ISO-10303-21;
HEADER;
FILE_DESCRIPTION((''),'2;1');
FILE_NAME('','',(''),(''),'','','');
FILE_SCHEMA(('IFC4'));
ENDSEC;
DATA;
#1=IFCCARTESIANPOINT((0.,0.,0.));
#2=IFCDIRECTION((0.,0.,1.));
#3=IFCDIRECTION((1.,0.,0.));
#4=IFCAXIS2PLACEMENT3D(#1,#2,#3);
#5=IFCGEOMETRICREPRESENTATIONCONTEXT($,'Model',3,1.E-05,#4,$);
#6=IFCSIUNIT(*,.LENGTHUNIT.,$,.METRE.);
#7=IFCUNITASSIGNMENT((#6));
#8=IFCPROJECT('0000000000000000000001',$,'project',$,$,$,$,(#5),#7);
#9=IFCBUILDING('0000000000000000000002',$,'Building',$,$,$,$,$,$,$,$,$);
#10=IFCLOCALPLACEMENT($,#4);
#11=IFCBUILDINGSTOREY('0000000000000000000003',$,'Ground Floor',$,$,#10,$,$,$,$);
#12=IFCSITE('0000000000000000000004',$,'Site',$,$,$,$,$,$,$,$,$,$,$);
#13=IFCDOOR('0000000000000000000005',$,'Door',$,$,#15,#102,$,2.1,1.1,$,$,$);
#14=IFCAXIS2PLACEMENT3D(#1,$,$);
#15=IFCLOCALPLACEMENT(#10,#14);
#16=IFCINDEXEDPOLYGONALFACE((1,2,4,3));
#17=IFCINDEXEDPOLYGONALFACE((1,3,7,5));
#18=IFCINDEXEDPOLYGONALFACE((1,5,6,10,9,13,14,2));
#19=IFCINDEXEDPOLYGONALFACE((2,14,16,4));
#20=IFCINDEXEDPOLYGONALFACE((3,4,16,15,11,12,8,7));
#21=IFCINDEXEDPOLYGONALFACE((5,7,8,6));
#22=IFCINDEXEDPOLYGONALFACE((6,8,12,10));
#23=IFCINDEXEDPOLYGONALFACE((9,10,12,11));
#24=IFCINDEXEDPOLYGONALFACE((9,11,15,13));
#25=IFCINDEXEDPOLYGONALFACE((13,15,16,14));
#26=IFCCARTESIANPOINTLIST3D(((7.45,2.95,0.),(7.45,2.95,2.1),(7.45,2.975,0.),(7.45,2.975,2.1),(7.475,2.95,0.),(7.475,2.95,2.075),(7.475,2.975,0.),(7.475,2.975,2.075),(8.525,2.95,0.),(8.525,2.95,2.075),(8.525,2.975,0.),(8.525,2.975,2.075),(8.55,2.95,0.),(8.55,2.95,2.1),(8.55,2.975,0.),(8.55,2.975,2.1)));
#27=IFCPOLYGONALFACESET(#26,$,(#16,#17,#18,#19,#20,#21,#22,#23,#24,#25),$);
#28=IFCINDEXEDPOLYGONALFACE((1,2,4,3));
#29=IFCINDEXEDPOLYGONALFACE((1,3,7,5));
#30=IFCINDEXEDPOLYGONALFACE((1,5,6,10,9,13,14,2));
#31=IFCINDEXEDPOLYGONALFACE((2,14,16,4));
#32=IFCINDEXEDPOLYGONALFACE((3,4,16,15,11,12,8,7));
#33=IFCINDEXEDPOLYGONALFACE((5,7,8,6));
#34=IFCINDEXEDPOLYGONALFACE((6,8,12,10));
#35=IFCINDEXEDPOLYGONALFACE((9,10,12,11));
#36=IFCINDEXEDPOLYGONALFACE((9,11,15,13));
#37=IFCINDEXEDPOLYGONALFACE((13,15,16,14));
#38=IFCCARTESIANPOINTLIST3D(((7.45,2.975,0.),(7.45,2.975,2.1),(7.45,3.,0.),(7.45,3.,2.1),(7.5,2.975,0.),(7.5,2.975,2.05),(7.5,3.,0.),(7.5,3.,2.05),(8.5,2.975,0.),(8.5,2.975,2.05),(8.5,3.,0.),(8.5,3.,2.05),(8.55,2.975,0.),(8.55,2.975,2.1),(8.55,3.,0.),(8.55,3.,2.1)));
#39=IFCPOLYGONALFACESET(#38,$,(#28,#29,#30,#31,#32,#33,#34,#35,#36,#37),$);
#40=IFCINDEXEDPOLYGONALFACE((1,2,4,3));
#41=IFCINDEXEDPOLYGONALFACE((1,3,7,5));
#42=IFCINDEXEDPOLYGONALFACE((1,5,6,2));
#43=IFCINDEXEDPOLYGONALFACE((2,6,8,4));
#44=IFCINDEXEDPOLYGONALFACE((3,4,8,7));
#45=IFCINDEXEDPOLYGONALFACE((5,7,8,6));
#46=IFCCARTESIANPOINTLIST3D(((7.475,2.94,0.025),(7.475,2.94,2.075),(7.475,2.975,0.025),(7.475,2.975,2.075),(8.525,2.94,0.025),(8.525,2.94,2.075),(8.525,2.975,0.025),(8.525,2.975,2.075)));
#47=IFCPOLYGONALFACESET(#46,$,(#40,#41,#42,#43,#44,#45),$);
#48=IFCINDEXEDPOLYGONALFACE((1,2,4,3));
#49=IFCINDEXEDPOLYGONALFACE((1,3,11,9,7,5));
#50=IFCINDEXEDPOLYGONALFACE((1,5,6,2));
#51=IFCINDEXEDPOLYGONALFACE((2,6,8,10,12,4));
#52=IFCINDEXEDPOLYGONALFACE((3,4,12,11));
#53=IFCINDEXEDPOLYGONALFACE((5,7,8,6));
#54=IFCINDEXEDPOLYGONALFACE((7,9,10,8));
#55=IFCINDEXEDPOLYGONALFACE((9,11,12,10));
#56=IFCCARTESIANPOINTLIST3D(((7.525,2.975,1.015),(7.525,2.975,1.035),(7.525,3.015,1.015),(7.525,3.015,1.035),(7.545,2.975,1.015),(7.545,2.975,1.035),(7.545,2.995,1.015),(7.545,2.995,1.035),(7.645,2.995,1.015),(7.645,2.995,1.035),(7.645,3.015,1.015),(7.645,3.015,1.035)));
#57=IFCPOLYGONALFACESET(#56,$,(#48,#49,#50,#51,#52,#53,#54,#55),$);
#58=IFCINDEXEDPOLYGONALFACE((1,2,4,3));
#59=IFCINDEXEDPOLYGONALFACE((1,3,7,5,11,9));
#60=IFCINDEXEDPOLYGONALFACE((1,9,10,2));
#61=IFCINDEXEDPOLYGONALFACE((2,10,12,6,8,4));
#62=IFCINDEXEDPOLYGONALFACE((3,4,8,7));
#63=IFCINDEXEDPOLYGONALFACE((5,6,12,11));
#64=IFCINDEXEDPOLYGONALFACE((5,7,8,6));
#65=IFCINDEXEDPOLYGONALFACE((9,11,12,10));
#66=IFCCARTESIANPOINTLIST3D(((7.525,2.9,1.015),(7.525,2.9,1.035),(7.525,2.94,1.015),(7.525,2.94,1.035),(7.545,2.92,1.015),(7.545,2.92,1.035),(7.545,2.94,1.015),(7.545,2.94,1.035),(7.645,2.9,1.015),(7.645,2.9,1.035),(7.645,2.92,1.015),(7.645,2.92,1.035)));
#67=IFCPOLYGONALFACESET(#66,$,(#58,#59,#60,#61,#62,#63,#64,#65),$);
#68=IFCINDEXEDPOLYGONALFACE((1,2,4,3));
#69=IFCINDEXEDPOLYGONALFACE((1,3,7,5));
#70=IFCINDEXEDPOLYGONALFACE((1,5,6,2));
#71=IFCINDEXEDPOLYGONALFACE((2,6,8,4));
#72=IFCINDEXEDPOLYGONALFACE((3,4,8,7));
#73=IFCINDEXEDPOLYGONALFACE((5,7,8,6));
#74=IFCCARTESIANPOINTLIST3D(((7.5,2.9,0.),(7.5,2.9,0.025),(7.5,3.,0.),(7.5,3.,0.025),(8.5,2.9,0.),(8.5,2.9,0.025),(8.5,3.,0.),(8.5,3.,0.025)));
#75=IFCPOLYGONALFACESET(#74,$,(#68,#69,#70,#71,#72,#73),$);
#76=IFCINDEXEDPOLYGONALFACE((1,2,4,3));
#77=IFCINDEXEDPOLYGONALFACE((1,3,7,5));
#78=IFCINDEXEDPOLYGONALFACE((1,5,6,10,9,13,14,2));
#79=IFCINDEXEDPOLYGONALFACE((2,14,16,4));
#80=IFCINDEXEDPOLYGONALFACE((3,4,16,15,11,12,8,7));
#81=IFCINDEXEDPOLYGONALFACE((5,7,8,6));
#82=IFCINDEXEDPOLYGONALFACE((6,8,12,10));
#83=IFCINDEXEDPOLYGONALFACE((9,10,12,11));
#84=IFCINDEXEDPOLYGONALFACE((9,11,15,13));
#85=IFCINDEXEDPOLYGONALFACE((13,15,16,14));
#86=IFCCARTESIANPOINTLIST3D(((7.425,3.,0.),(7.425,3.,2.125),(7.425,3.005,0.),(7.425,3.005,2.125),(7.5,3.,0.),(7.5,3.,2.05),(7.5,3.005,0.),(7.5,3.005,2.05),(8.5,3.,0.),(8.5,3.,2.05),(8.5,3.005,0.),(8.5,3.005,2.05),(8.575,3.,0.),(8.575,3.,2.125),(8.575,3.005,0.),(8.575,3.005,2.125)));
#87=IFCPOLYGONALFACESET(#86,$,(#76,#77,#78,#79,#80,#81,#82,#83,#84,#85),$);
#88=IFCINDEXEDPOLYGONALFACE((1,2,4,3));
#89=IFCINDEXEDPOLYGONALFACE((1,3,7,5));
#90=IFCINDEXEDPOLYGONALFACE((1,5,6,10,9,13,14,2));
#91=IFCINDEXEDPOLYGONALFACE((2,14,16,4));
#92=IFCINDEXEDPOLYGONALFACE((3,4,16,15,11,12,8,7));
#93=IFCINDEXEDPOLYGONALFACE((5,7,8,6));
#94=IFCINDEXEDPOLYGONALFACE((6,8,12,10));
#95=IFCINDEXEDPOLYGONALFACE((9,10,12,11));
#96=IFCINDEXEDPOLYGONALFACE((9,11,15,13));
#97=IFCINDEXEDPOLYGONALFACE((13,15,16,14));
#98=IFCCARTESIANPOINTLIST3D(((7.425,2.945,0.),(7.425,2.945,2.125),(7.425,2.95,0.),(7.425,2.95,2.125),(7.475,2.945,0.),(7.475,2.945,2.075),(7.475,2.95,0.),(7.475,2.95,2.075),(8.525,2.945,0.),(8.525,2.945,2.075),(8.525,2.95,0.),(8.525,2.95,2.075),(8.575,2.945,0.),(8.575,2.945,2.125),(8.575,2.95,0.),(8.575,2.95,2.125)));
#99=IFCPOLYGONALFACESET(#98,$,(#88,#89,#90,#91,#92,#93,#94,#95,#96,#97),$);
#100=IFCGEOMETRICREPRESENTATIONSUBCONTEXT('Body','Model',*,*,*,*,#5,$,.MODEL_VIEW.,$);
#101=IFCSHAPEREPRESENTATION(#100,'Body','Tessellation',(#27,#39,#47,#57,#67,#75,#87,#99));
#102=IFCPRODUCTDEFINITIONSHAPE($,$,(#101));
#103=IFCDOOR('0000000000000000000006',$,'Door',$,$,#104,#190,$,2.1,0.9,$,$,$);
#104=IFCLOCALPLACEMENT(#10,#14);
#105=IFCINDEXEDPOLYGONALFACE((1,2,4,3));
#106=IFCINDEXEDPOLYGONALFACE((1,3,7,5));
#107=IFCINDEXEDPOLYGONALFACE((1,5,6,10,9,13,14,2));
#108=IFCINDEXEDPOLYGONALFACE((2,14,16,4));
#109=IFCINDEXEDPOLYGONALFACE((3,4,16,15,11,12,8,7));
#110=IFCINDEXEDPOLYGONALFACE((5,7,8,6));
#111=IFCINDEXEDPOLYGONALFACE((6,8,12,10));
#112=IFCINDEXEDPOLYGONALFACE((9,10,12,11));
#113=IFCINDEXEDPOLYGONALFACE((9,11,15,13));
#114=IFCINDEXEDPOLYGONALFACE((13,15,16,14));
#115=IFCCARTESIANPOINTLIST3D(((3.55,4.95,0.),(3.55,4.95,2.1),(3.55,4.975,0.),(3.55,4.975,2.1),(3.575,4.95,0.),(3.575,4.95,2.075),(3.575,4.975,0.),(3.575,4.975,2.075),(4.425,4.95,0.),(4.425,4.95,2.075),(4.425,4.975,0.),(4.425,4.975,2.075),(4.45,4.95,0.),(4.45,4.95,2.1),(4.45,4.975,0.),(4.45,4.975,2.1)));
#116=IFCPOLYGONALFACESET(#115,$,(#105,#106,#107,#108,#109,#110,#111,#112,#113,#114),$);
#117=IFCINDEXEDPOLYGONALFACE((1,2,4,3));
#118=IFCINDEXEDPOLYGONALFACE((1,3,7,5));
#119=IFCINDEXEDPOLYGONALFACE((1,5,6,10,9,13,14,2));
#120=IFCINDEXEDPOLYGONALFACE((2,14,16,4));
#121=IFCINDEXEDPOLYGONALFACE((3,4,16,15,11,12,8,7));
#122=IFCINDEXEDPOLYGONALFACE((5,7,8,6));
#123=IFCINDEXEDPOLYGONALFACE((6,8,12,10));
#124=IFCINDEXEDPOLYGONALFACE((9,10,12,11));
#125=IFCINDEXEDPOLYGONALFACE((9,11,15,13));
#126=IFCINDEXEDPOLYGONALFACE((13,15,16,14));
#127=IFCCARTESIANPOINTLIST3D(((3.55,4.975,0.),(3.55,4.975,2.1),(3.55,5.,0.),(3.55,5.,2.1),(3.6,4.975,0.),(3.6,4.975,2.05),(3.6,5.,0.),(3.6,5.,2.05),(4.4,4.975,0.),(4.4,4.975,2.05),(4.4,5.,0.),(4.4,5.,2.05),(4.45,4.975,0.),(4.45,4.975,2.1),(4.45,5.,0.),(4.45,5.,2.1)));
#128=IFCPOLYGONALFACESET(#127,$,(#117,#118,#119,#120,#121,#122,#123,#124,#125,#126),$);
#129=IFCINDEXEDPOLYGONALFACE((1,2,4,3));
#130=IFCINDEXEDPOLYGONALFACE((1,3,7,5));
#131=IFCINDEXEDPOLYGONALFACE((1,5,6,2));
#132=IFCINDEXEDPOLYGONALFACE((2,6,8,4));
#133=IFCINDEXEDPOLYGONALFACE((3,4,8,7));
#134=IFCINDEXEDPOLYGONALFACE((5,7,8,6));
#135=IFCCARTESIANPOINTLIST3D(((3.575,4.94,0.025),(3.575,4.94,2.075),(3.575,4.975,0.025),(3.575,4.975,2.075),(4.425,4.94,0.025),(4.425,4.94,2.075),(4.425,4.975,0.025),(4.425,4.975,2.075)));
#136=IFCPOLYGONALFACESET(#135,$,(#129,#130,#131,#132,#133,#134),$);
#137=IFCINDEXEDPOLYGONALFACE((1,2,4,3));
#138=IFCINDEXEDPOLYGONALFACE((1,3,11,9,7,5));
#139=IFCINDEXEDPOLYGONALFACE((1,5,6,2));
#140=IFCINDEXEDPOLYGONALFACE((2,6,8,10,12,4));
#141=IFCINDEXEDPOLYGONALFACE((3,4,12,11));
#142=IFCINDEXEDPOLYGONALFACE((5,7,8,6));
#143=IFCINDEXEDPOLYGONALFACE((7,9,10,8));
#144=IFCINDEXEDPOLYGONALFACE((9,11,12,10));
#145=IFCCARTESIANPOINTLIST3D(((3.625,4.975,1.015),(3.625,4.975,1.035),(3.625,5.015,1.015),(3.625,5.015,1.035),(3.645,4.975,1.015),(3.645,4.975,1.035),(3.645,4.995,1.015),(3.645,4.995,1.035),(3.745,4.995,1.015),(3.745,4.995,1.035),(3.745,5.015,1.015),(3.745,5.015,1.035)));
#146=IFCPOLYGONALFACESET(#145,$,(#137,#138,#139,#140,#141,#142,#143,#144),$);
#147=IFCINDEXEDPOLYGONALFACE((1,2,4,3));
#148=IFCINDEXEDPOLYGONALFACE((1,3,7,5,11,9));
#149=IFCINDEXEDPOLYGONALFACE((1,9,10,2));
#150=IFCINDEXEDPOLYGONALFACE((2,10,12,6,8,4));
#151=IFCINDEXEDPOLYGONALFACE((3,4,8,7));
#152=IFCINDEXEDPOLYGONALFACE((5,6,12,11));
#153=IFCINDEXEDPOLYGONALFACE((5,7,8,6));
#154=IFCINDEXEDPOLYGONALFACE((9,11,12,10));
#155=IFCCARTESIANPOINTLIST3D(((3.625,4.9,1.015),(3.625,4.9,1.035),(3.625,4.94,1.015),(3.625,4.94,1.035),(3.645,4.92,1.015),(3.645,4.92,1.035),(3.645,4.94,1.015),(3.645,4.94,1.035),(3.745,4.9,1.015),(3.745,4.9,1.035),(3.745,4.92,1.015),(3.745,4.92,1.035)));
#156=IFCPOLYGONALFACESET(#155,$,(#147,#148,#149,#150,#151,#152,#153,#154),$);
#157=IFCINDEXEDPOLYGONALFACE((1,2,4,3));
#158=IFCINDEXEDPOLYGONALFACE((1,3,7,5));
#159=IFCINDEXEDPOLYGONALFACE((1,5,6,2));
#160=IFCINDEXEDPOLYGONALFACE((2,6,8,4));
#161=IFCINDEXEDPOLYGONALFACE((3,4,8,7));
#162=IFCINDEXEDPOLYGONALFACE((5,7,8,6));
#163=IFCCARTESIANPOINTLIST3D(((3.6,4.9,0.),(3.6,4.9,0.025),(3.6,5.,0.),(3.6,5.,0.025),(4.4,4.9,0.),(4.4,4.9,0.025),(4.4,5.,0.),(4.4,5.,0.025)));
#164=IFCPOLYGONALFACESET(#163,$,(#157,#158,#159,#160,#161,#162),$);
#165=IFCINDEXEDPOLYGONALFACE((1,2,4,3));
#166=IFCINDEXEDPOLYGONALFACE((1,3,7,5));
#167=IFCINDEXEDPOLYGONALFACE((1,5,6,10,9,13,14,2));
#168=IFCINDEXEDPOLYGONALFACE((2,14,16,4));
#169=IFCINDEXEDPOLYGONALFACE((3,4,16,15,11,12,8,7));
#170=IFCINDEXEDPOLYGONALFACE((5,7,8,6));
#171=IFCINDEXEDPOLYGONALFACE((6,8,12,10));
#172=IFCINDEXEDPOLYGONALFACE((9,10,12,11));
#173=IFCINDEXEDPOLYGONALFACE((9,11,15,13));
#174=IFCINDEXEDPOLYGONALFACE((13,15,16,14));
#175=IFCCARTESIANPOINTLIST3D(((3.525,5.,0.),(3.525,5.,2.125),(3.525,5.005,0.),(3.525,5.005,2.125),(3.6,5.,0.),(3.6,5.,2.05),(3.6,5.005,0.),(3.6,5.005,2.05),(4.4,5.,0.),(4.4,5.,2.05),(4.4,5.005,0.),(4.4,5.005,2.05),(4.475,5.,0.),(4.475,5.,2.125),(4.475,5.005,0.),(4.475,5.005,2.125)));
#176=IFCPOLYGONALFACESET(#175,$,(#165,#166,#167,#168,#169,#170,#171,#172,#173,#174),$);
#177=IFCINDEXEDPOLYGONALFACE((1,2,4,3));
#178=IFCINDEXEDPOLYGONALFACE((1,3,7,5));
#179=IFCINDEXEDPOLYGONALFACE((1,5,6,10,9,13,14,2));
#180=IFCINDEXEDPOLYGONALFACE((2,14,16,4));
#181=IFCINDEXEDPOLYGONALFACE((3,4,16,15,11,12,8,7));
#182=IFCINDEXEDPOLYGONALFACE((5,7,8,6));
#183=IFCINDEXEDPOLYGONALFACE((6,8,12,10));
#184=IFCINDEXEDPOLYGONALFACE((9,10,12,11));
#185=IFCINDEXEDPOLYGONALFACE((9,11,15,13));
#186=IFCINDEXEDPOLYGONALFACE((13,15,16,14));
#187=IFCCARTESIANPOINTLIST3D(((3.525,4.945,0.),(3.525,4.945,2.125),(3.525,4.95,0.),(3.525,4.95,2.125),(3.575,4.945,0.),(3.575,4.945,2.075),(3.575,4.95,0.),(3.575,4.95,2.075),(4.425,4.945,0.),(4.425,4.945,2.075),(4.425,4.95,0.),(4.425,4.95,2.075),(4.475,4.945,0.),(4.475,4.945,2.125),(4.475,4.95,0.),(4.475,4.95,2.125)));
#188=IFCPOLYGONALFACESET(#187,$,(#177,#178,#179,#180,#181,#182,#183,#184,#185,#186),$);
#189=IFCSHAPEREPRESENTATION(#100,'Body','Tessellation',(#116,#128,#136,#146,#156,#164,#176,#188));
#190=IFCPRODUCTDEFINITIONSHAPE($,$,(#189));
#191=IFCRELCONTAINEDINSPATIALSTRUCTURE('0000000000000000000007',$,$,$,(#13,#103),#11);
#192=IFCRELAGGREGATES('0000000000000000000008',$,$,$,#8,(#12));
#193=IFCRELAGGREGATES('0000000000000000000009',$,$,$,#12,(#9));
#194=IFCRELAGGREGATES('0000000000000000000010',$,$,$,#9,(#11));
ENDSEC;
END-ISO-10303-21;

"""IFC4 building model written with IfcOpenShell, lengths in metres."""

from ifc_helpers import new_model, si_unit, frame, origin_with_axes, place, context, subcontext, project, spatial, line, indexed_curve, outline, extrude, element, save


model = new_model("IFC4")

# Units and contexts
model_context = context("Model", 3, precision=1e-05, world=origin_with_axes())
body_context = subcontext(model_context, "Body", "Model", "MODEL_VIEW")
ifc_project = project(units=[si_unit("LENGTHUNIT", "METRE")], contexts=[model_context])

# Site, building, storey
site = spatial("IfcSite", under=ifc_project, Name="Site")
building = spatial("IfcBuilding", under=site, Name="Building")
storey_placement = place(None, origin_with_axes())
storey = spatial("IfcBuildingStorey", under=building, at=storey_placement, Name="Ground Floor")

# Doors
door_1_placement = place(storey_placement, frame((8.55, 3.0, 0.0), z_axis=(0.0, 0.0, 1.0), x_axis=(-1.0, 0.0, 0.0)))
element("IfcDoor", 1, at=door_1_placement, inside=storey, Name="Door", OverallHeight=2.1, OverallWidth=1.1, context=body_context, shape_type="SweptSolid", body=[
    extrude(outline(indexed_curve([(0.0, 0.0), (0.0, 2.1), (1.1, 2.1), (1.1, 0.0), (1.075, 0.0), (1.075, 2.075), (0.025, 2.075), (0.025, 0.0)], segments=[line(1, 2, 3, 4, 5, 6, 7, 8, 1)])), frame((0.0, 0.025, 0.0), z_axis=(0.0, -1.0, 0.0), x_axis=(1.0, 0.0, 0.0)), (0.0, 0.0, -1.0), 0.025),
    extrude(outline(indexed_curve([(0.0, 0.0), (0.0, 2.1), (1.1, 2.1), (1.1, 0.0), (1.05, 0.0), (1.05, 2.05), (0.05, 2.05), (0.05, 0.0)], segments=[line(1, 2, 3, 4, 5, 6, 7, 8, 1)])), frame((0.0, 0.0, 0.0), z_axis=(0.0, -1.0, 0.0), x_axis=(1.0, 0.0, 0.0)), (0.0, 0.0, -1.0), 0.025),
    extrude(outline(indexed_curve([(0.0, 0.0), (1.05, 0.0), (1.05, 0.035), (0.0, 0.035)], segments=[line(1, 2, 3, 4, 1)])), frame((0.025, 0.025, 0.025), z_axis=(0.0, 0.0, 1.0), x_axis=(1.0, 0.0, 0.0)), (0.0, 0.0, 1.0), 2.05),
    extrude(outline(indexed_curve([(0.0, 0.0), (0.0, -0.04), (-0.12, -0.04), (-0.12, -0.02), (-0.02, -0.02), (-0.02, 0.0)], segments=[line(1, 2, 3, 4, 5, 6, 1)])), frame((1.025, 0.025, 1.015), z_axis=(0.0, 0.0, 1.0), x_axis=(1.0, 0.0, 0.0)), (0.0, 0.0, 1.0), 0.02),
    extrude(outline(indexed_curve([(0.0, 0.0), (0.0, 0.04), (-0.12, 0.04), (-0.12, 0.02), (-0.02, 0.02), (-0.02, 0.0)], segments=[line(1, 2, 3, 4, 5, 6, 1)])), frame((1.025, 0.06, 1.015), z_axis=(0.0, 0.0, 1.0), x_axis=(1.0, 0.0, 0.0)), (0.0, 0.0, 1.0), 0.02),
    extrude(outline(indexed_curve([(0.0, 0.0), (1.0, 0.0), (1.0, 0.1), (0.0, 0.1)], segments=[line(1, 2, 3, 4, 1)])), frame((0.05, 0.0, 0.0), z_axis=(0.0, 0.0, 1.0), x_axis=(1.0, 0.0, 0.0)), (0.0, 0.0, 1.0), 0.025),
    extrude(outline(indexed_curve([(0.0, 0.0), (0.0, 2.125), (1.15, 2.125), (1.15, 0.0), (1.075, 0.0), (1.075, 2.05), (0.075, 2.05), (0.075, 0.0)], segments=[line(1, 2, 3, 4, 5, 6, 7, 8, 1)])), frame((-0.025, -0.005, 0.0), z_axis=(0.0, -1.0, 0.0), x_axis=(1.0, 0.0, 0.0)), (0.0, 0.0, -1.0), 0.005),
    extrude(outline(indexed_curve([(0.0, 0.0), (0.0, 2.125), (1.15, 2.125), (1.15, 0.0), (1.1, 0.0), (1.1, 2.075), (0.05, 2.075), (0.05, 0.0)], segments=[line(1, 2, 3, 4, 5, 6, 7, 8, 1)])), frame((-0.025, 0.05, 0.0), z_axis=(0.0, -1.0, 0.0), x_axis=(1.0, 0.0, 0.0)), (0.0, 0.0, -1.0), 0.005),
])
door_2_placement = place(storey_placement, frame((4.45, 5.0, 0.0), z_axis=(0.0, 0.0, 1.0), x_axis=(-1.0, 0.0, 0.0)))
element("IfcDoor", 2, at=door_2_placement, inside=storey, Name="Door", OverallHeight=2.1, OverallWidth=0.9, context=body_context, shape_type="SweptSolid", body=[
    extrude(outline(indexed_curve([(0.0, 0.0), (0.0, 2.1), (0.9, 2.1), (0.9, 0.0), (0.875, 0.0), (0.875, 2.075), (0.025, 2.075), (0.025, 0.0)], segments=[line(1, 2, 3, 4, 5, 6, 7, 8, 1)])), frame((0.0, 0.025, 0.0), z_axis=(0.0, -1.0, 0.0), x_axis=(1.0, 0.0, 0.0)), (0.0, 0.0, -1.0), 0.025),
    extrude(outline(indexed_curve([(0.0, 0.0), (0.0, 2.1), (0.9, 2.1), (0.9, 0.0), (0.85, 0.0), (0.85, 2.05), (0.05, 2.05), (0.05, 0.0)], segments=[line(1, 2, 3, 4, 5, 6, 7, 8, 1)])), frame((0.0, 0.0, 0.0), z_axis=(0.0, -1.0, 0.0), x_axis=(1.0, 0.0, 0.0)), (0.0, 0.0, -1.0), 0.025),
    extrude(outline(indexed_curve([(0.0, 0.0), (0.85, 0.0), (0.85, 0.035), (0.0, 0.035)], segments=[line(1, 2, 3, 4, 1)])), frame((0.025, 0.025, 0.025), z_axis=(0.0, 0.0, 1.0), x_axis=(1.0, 0.0, 0.0)), (0.0, 0.0, 1.0), 2.05),
    extrude(outline(indexed_curve([(0.0, 0.0), (0.0, -0.04), (-0.12, -0.04), (-0.12, -0.02), (-0.02, -0.02), (-0.02, 0.0)], segments=[line(1, 2, 3, 4, 5, 6, 1)])), frame((0.825, 0.025, 1.015), z_axis=(0.0, 0.0, 1.0), x_axis=(1.0, 0.0, 0.0)), (0.0, 0.0, 1.0), 0.02),
    extrude(outline(indexed_curve([(0.0, 0.0), (0.0, 0.04), (-0.12, 0.04), (-0.12, 0.02), (-0.02, 0.02), (-0.02, 0.0)], segments=[line(1, 2, 3, 4, 5, 6, 1)])), frame((0.825, 0.06, 1.015), z_axis=(0.0, 0.0, 1.0), x_axis=(1.0, 0.0, 0.0)), (0.0, 0.0, 1.0), 0.02),
    extrude(outline(indexed_curve([(0.0, 0.0), (0.8, 0.0), (0.8, 0.1), (0.0, 0.1)], segments=[line(1, 2, 3, 4, 1)])), frame((0.05, 0.0, 0.0), z_axis=(0.0, 0.0, 1.0), x_axis=(1.0, 0.0, 0.0)), (0.0, 0.0, 1.0), 0.025),
    extrude(outline(indexed_curve([(0.0, 0.0), (0.0, 2.125), (0.95, 2.125), (0.95, 0.0), (0.875, 0.0), (0.875, 2.05), (0.075, 2.05), (0.075, 0.0)], segments=[line(1, 2, 3, 4, 5, 6, 7, 8, 1)])), frame((-0.025, -0.005, 0.0), z_axis=(0.0, -1.0, 0.0), x_axis=(1.0, 0.0, 0.0)), (0.0, 0.0, -1.0), 0.005),
    extrude(outline(indexed_curve([(0.0, 0.0), (0.0, 2.125), (0.95, 2.125), (0.95, 0.0), (0.9, 0.0), (0.9, 2.075), (0.05, 2.075), (0.05, 0.0)], segments=[line(1, 2, 3, 4, 5, 6, 7, 8, 1)])), frame((-0.025, 0.05, 0.0), z_axis=(0.0, -1.0, 0.0), x_axis=(1.0, 0.0, 0.0)), (0.0, 0.0, -1.0), 0.005),
])

save(model, "model.ifc")
